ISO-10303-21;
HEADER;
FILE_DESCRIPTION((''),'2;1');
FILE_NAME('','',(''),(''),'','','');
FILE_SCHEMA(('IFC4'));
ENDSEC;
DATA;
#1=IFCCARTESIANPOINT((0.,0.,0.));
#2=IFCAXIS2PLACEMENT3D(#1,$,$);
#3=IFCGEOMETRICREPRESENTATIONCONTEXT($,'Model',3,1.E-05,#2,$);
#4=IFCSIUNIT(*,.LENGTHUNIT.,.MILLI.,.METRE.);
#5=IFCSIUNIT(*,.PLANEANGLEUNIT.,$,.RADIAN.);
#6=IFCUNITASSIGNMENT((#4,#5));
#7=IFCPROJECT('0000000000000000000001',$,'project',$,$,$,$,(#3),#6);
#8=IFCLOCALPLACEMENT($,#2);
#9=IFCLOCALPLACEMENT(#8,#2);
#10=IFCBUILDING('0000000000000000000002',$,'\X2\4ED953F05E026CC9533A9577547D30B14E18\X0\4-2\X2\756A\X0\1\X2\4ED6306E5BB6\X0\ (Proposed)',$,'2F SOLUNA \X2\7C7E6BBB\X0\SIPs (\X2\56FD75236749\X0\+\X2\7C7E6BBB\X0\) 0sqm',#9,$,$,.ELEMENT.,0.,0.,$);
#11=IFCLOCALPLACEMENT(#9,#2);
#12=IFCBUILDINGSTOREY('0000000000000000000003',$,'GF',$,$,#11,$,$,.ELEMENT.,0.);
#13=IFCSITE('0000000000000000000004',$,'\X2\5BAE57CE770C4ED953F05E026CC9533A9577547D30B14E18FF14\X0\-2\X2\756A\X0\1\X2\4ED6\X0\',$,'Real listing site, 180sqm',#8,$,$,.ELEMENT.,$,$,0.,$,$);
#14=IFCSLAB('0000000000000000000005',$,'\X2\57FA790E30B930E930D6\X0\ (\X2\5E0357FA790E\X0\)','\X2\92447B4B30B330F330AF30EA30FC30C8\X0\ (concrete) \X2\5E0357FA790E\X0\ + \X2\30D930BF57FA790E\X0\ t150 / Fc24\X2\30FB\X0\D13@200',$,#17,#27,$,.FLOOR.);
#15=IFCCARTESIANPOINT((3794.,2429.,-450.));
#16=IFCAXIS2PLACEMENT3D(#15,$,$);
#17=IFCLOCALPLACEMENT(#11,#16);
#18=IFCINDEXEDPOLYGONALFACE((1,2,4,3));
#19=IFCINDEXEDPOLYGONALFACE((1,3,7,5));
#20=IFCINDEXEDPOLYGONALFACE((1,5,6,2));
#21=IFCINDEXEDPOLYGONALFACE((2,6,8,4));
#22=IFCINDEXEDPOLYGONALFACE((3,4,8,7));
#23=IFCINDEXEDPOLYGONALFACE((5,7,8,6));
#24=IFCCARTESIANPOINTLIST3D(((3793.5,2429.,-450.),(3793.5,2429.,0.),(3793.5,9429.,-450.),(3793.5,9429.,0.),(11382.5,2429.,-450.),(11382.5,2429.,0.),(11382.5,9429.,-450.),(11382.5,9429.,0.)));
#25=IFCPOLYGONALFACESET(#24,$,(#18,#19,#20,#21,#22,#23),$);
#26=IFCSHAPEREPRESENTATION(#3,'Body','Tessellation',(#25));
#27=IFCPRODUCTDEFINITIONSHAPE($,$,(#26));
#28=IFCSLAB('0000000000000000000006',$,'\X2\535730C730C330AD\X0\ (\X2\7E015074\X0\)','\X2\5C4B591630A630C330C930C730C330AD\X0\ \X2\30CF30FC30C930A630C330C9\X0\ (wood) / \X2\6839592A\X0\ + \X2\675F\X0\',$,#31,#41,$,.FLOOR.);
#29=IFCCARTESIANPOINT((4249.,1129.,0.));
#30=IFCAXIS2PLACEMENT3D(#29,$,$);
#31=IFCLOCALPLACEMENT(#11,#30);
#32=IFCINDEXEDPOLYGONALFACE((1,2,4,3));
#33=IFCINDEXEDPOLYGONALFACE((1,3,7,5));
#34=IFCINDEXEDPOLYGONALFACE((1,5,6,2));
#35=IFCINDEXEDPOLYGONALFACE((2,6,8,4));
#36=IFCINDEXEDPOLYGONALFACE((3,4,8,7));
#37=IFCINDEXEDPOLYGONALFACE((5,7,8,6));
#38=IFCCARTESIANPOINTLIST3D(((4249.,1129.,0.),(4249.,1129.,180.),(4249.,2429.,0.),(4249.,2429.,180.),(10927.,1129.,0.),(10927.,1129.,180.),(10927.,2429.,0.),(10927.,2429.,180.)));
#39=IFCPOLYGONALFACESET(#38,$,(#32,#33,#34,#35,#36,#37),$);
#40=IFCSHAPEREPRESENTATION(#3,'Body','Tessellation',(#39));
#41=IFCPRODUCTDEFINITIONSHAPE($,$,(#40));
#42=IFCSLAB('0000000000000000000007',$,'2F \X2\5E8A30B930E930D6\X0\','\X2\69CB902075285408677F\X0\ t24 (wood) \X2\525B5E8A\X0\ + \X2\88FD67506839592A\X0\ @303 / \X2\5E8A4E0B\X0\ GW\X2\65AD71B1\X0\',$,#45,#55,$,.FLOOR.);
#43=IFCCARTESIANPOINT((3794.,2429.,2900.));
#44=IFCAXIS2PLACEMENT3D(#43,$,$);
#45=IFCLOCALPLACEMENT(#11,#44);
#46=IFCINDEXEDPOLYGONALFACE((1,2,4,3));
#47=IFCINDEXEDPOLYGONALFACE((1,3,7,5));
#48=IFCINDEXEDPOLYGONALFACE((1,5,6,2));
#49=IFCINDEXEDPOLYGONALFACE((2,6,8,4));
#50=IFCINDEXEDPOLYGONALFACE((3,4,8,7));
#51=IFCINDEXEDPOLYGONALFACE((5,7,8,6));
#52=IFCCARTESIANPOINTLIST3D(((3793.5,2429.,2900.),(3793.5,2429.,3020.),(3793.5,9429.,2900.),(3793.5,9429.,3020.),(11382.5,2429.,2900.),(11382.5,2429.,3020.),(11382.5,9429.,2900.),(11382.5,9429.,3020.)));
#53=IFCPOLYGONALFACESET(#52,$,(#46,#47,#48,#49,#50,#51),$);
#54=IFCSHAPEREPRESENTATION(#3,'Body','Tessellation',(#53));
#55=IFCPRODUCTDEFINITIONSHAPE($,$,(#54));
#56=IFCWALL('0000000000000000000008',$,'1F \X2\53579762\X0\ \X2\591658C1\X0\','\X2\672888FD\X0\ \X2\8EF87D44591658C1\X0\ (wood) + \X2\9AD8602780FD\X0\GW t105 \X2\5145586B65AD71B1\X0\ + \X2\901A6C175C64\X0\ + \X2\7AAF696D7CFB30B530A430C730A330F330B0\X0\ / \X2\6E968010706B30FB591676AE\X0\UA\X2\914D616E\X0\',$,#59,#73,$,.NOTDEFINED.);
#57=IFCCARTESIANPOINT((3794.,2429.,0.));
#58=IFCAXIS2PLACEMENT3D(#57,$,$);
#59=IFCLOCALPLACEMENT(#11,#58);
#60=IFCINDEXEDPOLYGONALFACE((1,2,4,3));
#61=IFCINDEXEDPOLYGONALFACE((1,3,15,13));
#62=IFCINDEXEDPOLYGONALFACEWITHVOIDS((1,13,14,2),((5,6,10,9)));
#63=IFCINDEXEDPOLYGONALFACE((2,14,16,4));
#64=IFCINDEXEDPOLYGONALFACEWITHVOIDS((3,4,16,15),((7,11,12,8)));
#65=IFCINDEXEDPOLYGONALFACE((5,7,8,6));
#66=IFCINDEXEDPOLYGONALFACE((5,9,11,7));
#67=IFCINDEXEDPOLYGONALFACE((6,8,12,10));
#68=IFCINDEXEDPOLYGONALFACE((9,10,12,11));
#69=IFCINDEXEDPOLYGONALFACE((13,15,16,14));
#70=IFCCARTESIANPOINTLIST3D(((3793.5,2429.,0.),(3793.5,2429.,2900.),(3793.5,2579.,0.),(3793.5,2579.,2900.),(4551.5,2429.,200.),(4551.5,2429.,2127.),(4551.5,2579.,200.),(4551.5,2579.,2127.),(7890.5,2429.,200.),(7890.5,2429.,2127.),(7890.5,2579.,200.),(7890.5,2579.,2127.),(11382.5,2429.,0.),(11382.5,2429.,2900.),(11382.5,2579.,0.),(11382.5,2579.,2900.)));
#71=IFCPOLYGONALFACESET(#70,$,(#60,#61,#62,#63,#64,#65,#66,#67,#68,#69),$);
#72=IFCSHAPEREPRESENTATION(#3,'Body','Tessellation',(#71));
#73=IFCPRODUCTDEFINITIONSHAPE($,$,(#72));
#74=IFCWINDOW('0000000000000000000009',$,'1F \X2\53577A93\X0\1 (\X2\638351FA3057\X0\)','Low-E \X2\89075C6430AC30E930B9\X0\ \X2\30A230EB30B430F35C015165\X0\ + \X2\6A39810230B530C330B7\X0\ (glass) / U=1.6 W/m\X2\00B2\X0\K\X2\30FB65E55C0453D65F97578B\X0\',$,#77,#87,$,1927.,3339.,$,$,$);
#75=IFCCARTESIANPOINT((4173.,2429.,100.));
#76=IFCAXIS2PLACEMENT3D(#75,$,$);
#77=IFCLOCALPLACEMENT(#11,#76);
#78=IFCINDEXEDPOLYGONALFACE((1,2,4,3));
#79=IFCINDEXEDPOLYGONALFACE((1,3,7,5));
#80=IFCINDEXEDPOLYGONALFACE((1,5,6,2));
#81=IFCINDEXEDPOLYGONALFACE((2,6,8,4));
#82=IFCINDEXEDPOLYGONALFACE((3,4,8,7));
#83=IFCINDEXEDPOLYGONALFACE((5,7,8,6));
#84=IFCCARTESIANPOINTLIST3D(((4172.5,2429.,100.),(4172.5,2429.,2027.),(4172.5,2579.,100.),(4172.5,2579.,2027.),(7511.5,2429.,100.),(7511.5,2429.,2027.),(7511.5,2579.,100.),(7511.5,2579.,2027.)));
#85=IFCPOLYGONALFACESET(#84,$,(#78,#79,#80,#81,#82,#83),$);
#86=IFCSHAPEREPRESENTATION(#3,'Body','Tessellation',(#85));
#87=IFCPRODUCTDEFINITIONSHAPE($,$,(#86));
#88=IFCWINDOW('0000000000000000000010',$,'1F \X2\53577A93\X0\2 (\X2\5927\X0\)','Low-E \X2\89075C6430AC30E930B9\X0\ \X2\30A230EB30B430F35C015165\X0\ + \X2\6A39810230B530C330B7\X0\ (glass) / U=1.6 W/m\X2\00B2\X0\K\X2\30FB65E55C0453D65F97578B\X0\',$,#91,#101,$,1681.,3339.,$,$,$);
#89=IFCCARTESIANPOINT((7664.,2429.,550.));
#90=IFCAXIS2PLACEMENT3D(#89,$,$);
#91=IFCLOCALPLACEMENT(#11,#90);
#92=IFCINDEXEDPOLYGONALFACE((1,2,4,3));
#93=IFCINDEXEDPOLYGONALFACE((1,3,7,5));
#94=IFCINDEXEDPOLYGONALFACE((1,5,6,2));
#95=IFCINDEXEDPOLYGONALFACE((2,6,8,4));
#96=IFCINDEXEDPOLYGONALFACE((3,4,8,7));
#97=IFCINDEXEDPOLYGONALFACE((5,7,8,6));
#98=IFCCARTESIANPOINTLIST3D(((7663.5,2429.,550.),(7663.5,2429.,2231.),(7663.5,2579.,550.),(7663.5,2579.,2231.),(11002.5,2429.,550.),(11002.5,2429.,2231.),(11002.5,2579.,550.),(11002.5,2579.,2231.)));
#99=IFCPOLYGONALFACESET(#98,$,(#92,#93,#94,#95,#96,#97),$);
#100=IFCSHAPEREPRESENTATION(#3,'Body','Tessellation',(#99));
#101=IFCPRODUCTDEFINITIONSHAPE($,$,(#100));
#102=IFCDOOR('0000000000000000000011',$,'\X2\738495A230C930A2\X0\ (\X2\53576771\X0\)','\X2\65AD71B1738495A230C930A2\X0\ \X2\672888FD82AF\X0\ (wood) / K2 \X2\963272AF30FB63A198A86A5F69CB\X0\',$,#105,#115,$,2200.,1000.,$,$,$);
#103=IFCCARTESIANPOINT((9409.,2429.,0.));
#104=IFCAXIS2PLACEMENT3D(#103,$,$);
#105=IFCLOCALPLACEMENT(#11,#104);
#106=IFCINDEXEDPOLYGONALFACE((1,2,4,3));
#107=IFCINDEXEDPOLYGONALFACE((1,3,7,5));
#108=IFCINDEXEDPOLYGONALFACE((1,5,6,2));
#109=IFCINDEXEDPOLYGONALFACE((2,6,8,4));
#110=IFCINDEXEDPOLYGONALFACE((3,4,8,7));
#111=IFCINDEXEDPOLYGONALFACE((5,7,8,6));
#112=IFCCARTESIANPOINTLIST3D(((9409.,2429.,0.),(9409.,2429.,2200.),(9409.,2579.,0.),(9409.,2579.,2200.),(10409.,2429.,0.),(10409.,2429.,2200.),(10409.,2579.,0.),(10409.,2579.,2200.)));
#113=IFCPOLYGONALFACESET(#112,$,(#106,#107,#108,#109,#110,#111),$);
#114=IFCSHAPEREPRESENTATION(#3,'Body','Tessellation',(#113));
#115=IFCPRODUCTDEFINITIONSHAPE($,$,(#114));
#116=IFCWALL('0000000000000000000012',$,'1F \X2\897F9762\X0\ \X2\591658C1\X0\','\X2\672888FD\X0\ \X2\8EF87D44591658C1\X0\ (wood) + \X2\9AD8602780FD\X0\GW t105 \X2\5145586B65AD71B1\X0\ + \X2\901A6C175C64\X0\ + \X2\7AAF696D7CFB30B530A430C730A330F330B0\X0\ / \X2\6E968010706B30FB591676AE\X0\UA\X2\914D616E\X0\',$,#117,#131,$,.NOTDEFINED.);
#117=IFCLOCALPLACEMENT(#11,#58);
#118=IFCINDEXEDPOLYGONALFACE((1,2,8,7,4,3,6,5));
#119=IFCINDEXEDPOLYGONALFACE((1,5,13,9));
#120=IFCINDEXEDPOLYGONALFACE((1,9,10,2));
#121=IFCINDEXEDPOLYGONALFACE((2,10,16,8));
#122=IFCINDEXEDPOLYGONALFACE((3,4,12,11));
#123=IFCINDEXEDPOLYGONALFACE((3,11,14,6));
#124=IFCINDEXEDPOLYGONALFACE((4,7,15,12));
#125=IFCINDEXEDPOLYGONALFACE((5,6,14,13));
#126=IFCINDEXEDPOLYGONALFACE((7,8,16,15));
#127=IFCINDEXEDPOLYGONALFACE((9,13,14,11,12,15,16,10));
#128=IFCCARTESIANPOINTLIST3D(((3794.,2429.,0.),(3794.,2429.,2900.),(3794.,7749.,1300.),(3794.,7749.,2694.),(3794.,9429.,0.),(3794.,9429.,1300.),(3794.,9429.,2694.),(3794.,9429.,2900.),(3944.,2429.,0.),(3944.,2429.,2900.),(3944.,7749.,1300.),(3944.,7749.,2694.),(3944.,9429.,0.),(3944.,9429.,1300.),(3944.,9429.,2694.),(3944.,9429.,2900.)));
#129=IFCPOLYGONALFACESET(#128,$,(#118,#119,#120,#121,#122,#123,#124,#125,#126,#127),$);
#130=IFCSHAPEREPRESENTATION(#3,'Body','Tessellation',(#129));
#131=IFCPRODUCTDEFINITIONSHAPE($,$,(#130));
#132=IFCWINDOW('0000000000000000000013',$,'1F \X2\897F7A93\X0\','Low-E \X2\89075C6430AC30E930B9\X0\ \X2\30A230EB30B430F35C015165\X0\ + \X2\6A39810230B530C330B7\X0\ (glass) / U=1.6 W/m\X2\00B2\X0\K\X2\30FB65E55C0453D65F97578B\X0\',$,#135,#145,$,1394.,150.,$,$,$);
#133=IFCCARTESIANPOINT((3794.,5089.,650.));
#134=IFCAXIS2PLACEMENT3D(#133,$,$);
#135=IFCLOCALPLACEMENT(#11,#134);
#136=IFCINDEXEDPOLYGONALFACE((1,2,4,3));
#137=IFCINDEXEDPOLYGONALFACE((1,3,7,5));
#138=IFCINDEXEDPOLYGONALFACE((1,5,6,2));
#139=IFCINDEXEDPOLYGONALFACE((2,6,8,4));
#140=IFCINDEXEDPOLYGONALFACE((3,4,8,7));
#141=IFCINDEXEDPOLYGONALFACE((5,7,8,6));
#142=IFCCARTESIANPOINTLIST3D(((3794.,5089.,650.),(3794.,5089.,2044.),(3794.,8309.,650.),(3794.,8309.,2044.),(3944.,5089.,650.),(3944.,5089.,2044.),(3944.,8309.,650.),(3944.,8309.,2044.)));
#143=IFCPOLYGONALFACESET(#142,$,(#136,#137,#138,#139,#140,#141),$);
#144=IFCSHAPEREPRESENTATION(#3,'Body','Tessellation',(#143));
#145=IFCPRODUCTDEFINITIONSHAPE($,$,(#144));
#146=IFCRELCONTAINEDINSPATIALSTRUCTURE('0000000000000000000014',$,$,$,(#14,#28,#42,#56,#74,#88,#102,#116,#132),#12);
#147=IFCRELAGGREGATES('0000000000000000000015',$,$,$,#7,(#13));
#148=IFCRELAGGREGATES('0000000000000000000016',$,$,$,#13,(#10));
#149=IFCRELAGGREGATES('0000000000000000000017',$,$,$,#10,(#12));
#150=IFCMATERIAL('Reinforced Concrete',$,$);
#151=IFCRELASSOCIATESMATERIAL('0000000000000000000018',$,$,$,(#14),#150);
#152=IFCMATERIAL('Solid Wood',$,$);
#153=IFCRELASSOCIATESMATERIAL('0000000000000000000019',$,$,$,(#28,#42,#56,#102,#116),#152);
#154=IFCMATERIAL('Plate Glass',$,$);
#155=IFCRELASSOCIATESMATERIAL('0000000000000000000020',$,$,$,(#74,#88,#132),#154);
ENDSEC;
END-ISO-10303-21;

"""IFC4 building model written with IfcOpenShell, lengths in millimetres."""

from ifc_helpers import new_model, si_unit, frame, frame_2d, origin, place, context, project, spatial, rectangle, extrude, material, element, fill, save


model = new_model("IFC4")

# Units and contexts
model_context = context("Model", 3, precision=1e-05, world=origin())
ifc_project = project(units=[si_unit("LENGTHUNIT", "METRE", prefix="MILLI"), si_unit("PLANEANGLEUNIT", "RADIAN")], contexts=[model_context])

# Site, building, storey
site_placement = place(None, origin())
site = spatial("IfcSite", under=ifc_project, at=site_placement, Name="宮城県仙台市泉区長命ケ丘４-2番1他", ObjectType="Real listing site, 180sqm", CompositionType="ELEMENT", RefElevation=0.0)
building_placement = place(site_placement, origin())
building = spatial("IfcBuilding", under=site, at=building_placement, Name="仙台市泉区長命ケ丘4-2番1他の家 (Proposed)", ObjectType="2F SOLUNA 籾殻SIPs (国産杉+籾殻) 0sqm", CompositionType="ELEMENT", ElevationOfRefHeight=0.0, ElevationOfTerrain=0.0)
storey_placement = place(building_placement, origin())
storey = spatial("IfcBuildingStorey", under=building, at=storey_placement, Name="GF", CompositionType="ELEMENT", Elevation=0.0)

# Slabs
ifc_material_1 = material(Name="Reinforced Concrete")
slab_1_placement = place(storey_placement, frame((3794.0, 2429.0, -450.0)))
element("IfcSlab", 1, at=slab_1_placement, inside=storey, material=ifc_material_1, Name="基礎スラブ (布基礎)", Description="鉄筋コンクリート (concrete) 布基礎 + ベタ基礎 t150 / Fc24・D13@200", PredefinedType="FLOOR", context=model_context, shape_type="SweptSolid", body=[
    extrude(rectangle(XDim=7589.0, YDim=7000.0, at=frame_2d((3794.0, 3500.0))), frame((3794.0, 2429.0, -450.0)), (0.0, 0.0, 1.0), 450.0),
])
ifc_material_2 = material(Name="Solid Wood")
slab_2_placement = place(storey_placement, frame((4249.0, 1129.0, 0.0)))
element("IfcSlab", 2, at=slab_2_placement, inside=storey, material=ifc_material_2, Name="南デッキ (縁側)", Description="屋外ウッドデッキ ハードウッド (wood) / 根太 + 束", PredefinedType="FLOOR", context=model_context, shape_type="SweptSolid", body=[
    extrude(rectangle(XDim=6678.0, YDim=1300.0, at=frame_2d((3339.0, 650.0))), frame((4249.0, 1129.0, 0.0)), (0.0, 0.0, 1.0), 180.0),
])
slab_3_placement = place(storey_placement, frame((3794.0, 2429.0, 2900.0)))
element("IfcSlab", 3, at=slab_3_placement, inside=storey, material=ifc_material_2, Name="2F 床スラブ", Description="構造用合板 t24 (wood) 剛床 + 製材根太 @303 / 床下 GW断熱", PredefinedType="FLOOR", context=model_context, shape_type="SweptSolid", body=[
    extrude(rectangle(XDim=7589.0, YDim=7000.0, at=frame_2d((3794.0, 3500.0))), frame((3794.0, 2429.0, 2900.0)), (0.0, 0.0, 1.0), 120.0),
])

# Wall, openings, windows, door
wall_1_placement = place(storey_placement, frame((3794.0, 2429.0, 0.0)))
wall_1 = element("IfcWall", 4, at=wall_1_placement, inside=storey, material=ifc_material_2, Name="1F 南面 外壁", Description="木製 軸組外壁 (wood) + 高性能GW t105 充填断熱 + 通気層 + 窯業系サイディング / 準耐火・外皮UA配慮", PredefinedType="NOTDEFINED", context=model_context, shape_type="SweptSolid", body=[
    extrude(rectangle(XDim=7589.0, YDim=150.0, at=frame_2d((3794.0, 75.0))), frame((3794.0, 2429.0, 0.0)), (0.0, 0.0, 1.0), 2900.0),
])
opening_1_placement = place(storey_placement, frame((4173.0, 2429.0, 100.0)))
opening_1 = element("IfcOpeningElement", 5, at=opening_1_placement, cuts=wall_1, PredefinedType="NOTDEFINED", context=model_context, shape_type="SweptSolid", body=[
    extrude(rectangle(XDim=3339.0, YDim=150.0, at=frame_2d((1669.0, 75.0))), frame((4173.0, 2429.0, 100.0)), (0.0, 0.0, 1.0), 1927.0),
])
opening_2_placement = place(storey_placement, frame((7664.0, 2429.0, 550.0)))
opening_2 = element("IfcOpeningElement", 6, at=opening_2_placement, cuts=wall_1, PredefinedType="NOTDEFINED", context=model_context, shape_type="SweptSolid", body=[
    extrude(rectangle(XDim=3339.0, YDim=150.0, at=frame_2d((1669.0, 75.0))), frame((7664.0, 2429.0, 550.0)), (0.0, 0.0, 1.0), 1681.0),
])
opening_3_placement = place(storey_placement, frame((9409.0, 2429.0, 0.0)))
opening_3 = element("IfcOpeningElement", 7, at=opening_3_placement, cuts=wall_1, PredefinedType="NOTDEFINED", context=model_context, shape_type="SweptSolid", body=[
    extrude(rectangle(XDim=1000.0, YDim=150.0, at=frame_2d((500.0, 75.0))), frame((9409.0, 2429.0, 0.0)), (0.0, 0.0, 1.0), 2200.0),
])
ifc_material_3 = material(Name="Plate Glass")
window_1_placement = place(storey_placement, frame((4173.0, 2429.0, 100.0)))
window_1 = element("IfcWindow", 8, at=window_1_placement, inside=storey, material=ifc_material_3, Name="1F 南窓1 (掃出し)", Description="Low-E 複層ガラス アルゴン封入 + 樹脂サッシ (glass) / U=1.6 W/m²K・日射取得型", OverallHeight=1927.0, OverallWidth=3339.0, context=model_context, shape_type="SweptSolid", body=[
    extrude(rectangle(XDim=3339.0, YDim=150.0, at=frame_2d((1669.0, 75.0))), frame((4173.0, 2429.0, 100.0)), (0.0, 0.0, 1.0), 1927.0),
])
fill(opening_1, window_1)
window_2_placement = place(storey_placement, frame((7664.0, 2429.0, 550.0)))
window_2 = element("IfcWindow", 9, at=window_2_placement, inside=storey, material=ifc_material_3, Name="1F 南窓2 (大)", Description="Low-E 複層ガラス アルゴン封入 + 樹脂サッシ (glass) / U=1.6 W/m²K・日射取得型", OverallHeight=1681.0, OverallWidth=3339.0, context=model_context, shape_type="SweptSolid", body=[
    extrude(rectangle(XDim=3339.0, YDim=150.0, at=frame_2d((1669.0, 75.0))), frame((7664.0, 2429.0, 550.0)), (0.0, 0.0, 1.0), 1681.0),
])
fill(opening_2, window_2)
door_placement = place(storey_placement, frame((9409.0, 2429.0, 0.0)))
door = element("IfcDoor", 10, at=door_placement, inside=storey, material=ifc_material_2, Name="玄関ドア (南東)", Description="断熱玄関ドア 木製芯 (wood) / K2 防犯・採風機構", OverallHeight=2200.0, OverallWidth=1000.0, context=model_context, shape_type="SweptSolid", body=[
    extrude(rectangle(XDim=1000.0, YDim=150.0, at=frame_2d((500.0, 75.0))), frame((9409.0, 2429.0, 0.0)), (0.0, 0.0, 1.0), 2200.0),
])
fill(opening_3, door)

# Wall, opening, window
wall_2_placement = place(storey_placement, frame((3794.0, 2429.0, 0.0)))
wall_2 = element("IfcWall", 11, at=wall_2_placement, inside=storey, material=ifc_material_2, Name="1F 西面 外壁", Description="木製 軸組外壁 (wood) + 高性能GW t105 充填断熱 + 通気層 + 窯業系サイディング / 準耐火・外皮UA配慮", PredefinedType="NOTDEFINED", context=model_context, shape_type="SweptSolid", body=[
    extrude(rectangle(XDim=150.0, YDim=7000.0, at=frame_2d((75.0, 3500.0))), frame((3794.0, 2429.0, 0.0)), (0.0, 0.0, 1.0), 2900.0),
])
opening_4_placement = place(storey_placement, frame((3794.0, 5089.0, 650.0)))
opening_4 = element("IfcOpeningElement", 12, at=opening_4_placement, cuts=wall_2, PredefinedType="NOTDEFINED", context=model_context, shape_type="SweptSolid", body=[
    extrude(rectangle(XDim=150.0, YDim=3220.0, at=frame_2d((75.0, 1610.0))), frame((3794.0, 5089.0, 650.0)), (0.0, 0.0, 1.0), 1394.0),
])
window_3_placement = place(storey_placement, frame((3794.0, 5089.0, 650.0)))
window_3 = element("IfcWindow", 13, at=window_3_placement, inside=storey, material=ifc_material_3, Name="1F 西窓", Description="Low-E 複層ガラス アルゴン封入 + 樹脂サッシ (glass) / U=1.6 W/m²K・日射取得型", OverallHeight=1394.0, OverallWidth=150.0, context=model_context, shape_type="SweptSolid", body=[
    extrude(rectangle(XDim=150.0, YDim=3220.0, at=frame_2d((75.0, 1610.0))), frame((3794.0, 5089.0, 650.0)), (0.0, 0.0, 1.0), 1394.0),
])
fill(opening_4, window_3)

save(model, "model.ifc")
